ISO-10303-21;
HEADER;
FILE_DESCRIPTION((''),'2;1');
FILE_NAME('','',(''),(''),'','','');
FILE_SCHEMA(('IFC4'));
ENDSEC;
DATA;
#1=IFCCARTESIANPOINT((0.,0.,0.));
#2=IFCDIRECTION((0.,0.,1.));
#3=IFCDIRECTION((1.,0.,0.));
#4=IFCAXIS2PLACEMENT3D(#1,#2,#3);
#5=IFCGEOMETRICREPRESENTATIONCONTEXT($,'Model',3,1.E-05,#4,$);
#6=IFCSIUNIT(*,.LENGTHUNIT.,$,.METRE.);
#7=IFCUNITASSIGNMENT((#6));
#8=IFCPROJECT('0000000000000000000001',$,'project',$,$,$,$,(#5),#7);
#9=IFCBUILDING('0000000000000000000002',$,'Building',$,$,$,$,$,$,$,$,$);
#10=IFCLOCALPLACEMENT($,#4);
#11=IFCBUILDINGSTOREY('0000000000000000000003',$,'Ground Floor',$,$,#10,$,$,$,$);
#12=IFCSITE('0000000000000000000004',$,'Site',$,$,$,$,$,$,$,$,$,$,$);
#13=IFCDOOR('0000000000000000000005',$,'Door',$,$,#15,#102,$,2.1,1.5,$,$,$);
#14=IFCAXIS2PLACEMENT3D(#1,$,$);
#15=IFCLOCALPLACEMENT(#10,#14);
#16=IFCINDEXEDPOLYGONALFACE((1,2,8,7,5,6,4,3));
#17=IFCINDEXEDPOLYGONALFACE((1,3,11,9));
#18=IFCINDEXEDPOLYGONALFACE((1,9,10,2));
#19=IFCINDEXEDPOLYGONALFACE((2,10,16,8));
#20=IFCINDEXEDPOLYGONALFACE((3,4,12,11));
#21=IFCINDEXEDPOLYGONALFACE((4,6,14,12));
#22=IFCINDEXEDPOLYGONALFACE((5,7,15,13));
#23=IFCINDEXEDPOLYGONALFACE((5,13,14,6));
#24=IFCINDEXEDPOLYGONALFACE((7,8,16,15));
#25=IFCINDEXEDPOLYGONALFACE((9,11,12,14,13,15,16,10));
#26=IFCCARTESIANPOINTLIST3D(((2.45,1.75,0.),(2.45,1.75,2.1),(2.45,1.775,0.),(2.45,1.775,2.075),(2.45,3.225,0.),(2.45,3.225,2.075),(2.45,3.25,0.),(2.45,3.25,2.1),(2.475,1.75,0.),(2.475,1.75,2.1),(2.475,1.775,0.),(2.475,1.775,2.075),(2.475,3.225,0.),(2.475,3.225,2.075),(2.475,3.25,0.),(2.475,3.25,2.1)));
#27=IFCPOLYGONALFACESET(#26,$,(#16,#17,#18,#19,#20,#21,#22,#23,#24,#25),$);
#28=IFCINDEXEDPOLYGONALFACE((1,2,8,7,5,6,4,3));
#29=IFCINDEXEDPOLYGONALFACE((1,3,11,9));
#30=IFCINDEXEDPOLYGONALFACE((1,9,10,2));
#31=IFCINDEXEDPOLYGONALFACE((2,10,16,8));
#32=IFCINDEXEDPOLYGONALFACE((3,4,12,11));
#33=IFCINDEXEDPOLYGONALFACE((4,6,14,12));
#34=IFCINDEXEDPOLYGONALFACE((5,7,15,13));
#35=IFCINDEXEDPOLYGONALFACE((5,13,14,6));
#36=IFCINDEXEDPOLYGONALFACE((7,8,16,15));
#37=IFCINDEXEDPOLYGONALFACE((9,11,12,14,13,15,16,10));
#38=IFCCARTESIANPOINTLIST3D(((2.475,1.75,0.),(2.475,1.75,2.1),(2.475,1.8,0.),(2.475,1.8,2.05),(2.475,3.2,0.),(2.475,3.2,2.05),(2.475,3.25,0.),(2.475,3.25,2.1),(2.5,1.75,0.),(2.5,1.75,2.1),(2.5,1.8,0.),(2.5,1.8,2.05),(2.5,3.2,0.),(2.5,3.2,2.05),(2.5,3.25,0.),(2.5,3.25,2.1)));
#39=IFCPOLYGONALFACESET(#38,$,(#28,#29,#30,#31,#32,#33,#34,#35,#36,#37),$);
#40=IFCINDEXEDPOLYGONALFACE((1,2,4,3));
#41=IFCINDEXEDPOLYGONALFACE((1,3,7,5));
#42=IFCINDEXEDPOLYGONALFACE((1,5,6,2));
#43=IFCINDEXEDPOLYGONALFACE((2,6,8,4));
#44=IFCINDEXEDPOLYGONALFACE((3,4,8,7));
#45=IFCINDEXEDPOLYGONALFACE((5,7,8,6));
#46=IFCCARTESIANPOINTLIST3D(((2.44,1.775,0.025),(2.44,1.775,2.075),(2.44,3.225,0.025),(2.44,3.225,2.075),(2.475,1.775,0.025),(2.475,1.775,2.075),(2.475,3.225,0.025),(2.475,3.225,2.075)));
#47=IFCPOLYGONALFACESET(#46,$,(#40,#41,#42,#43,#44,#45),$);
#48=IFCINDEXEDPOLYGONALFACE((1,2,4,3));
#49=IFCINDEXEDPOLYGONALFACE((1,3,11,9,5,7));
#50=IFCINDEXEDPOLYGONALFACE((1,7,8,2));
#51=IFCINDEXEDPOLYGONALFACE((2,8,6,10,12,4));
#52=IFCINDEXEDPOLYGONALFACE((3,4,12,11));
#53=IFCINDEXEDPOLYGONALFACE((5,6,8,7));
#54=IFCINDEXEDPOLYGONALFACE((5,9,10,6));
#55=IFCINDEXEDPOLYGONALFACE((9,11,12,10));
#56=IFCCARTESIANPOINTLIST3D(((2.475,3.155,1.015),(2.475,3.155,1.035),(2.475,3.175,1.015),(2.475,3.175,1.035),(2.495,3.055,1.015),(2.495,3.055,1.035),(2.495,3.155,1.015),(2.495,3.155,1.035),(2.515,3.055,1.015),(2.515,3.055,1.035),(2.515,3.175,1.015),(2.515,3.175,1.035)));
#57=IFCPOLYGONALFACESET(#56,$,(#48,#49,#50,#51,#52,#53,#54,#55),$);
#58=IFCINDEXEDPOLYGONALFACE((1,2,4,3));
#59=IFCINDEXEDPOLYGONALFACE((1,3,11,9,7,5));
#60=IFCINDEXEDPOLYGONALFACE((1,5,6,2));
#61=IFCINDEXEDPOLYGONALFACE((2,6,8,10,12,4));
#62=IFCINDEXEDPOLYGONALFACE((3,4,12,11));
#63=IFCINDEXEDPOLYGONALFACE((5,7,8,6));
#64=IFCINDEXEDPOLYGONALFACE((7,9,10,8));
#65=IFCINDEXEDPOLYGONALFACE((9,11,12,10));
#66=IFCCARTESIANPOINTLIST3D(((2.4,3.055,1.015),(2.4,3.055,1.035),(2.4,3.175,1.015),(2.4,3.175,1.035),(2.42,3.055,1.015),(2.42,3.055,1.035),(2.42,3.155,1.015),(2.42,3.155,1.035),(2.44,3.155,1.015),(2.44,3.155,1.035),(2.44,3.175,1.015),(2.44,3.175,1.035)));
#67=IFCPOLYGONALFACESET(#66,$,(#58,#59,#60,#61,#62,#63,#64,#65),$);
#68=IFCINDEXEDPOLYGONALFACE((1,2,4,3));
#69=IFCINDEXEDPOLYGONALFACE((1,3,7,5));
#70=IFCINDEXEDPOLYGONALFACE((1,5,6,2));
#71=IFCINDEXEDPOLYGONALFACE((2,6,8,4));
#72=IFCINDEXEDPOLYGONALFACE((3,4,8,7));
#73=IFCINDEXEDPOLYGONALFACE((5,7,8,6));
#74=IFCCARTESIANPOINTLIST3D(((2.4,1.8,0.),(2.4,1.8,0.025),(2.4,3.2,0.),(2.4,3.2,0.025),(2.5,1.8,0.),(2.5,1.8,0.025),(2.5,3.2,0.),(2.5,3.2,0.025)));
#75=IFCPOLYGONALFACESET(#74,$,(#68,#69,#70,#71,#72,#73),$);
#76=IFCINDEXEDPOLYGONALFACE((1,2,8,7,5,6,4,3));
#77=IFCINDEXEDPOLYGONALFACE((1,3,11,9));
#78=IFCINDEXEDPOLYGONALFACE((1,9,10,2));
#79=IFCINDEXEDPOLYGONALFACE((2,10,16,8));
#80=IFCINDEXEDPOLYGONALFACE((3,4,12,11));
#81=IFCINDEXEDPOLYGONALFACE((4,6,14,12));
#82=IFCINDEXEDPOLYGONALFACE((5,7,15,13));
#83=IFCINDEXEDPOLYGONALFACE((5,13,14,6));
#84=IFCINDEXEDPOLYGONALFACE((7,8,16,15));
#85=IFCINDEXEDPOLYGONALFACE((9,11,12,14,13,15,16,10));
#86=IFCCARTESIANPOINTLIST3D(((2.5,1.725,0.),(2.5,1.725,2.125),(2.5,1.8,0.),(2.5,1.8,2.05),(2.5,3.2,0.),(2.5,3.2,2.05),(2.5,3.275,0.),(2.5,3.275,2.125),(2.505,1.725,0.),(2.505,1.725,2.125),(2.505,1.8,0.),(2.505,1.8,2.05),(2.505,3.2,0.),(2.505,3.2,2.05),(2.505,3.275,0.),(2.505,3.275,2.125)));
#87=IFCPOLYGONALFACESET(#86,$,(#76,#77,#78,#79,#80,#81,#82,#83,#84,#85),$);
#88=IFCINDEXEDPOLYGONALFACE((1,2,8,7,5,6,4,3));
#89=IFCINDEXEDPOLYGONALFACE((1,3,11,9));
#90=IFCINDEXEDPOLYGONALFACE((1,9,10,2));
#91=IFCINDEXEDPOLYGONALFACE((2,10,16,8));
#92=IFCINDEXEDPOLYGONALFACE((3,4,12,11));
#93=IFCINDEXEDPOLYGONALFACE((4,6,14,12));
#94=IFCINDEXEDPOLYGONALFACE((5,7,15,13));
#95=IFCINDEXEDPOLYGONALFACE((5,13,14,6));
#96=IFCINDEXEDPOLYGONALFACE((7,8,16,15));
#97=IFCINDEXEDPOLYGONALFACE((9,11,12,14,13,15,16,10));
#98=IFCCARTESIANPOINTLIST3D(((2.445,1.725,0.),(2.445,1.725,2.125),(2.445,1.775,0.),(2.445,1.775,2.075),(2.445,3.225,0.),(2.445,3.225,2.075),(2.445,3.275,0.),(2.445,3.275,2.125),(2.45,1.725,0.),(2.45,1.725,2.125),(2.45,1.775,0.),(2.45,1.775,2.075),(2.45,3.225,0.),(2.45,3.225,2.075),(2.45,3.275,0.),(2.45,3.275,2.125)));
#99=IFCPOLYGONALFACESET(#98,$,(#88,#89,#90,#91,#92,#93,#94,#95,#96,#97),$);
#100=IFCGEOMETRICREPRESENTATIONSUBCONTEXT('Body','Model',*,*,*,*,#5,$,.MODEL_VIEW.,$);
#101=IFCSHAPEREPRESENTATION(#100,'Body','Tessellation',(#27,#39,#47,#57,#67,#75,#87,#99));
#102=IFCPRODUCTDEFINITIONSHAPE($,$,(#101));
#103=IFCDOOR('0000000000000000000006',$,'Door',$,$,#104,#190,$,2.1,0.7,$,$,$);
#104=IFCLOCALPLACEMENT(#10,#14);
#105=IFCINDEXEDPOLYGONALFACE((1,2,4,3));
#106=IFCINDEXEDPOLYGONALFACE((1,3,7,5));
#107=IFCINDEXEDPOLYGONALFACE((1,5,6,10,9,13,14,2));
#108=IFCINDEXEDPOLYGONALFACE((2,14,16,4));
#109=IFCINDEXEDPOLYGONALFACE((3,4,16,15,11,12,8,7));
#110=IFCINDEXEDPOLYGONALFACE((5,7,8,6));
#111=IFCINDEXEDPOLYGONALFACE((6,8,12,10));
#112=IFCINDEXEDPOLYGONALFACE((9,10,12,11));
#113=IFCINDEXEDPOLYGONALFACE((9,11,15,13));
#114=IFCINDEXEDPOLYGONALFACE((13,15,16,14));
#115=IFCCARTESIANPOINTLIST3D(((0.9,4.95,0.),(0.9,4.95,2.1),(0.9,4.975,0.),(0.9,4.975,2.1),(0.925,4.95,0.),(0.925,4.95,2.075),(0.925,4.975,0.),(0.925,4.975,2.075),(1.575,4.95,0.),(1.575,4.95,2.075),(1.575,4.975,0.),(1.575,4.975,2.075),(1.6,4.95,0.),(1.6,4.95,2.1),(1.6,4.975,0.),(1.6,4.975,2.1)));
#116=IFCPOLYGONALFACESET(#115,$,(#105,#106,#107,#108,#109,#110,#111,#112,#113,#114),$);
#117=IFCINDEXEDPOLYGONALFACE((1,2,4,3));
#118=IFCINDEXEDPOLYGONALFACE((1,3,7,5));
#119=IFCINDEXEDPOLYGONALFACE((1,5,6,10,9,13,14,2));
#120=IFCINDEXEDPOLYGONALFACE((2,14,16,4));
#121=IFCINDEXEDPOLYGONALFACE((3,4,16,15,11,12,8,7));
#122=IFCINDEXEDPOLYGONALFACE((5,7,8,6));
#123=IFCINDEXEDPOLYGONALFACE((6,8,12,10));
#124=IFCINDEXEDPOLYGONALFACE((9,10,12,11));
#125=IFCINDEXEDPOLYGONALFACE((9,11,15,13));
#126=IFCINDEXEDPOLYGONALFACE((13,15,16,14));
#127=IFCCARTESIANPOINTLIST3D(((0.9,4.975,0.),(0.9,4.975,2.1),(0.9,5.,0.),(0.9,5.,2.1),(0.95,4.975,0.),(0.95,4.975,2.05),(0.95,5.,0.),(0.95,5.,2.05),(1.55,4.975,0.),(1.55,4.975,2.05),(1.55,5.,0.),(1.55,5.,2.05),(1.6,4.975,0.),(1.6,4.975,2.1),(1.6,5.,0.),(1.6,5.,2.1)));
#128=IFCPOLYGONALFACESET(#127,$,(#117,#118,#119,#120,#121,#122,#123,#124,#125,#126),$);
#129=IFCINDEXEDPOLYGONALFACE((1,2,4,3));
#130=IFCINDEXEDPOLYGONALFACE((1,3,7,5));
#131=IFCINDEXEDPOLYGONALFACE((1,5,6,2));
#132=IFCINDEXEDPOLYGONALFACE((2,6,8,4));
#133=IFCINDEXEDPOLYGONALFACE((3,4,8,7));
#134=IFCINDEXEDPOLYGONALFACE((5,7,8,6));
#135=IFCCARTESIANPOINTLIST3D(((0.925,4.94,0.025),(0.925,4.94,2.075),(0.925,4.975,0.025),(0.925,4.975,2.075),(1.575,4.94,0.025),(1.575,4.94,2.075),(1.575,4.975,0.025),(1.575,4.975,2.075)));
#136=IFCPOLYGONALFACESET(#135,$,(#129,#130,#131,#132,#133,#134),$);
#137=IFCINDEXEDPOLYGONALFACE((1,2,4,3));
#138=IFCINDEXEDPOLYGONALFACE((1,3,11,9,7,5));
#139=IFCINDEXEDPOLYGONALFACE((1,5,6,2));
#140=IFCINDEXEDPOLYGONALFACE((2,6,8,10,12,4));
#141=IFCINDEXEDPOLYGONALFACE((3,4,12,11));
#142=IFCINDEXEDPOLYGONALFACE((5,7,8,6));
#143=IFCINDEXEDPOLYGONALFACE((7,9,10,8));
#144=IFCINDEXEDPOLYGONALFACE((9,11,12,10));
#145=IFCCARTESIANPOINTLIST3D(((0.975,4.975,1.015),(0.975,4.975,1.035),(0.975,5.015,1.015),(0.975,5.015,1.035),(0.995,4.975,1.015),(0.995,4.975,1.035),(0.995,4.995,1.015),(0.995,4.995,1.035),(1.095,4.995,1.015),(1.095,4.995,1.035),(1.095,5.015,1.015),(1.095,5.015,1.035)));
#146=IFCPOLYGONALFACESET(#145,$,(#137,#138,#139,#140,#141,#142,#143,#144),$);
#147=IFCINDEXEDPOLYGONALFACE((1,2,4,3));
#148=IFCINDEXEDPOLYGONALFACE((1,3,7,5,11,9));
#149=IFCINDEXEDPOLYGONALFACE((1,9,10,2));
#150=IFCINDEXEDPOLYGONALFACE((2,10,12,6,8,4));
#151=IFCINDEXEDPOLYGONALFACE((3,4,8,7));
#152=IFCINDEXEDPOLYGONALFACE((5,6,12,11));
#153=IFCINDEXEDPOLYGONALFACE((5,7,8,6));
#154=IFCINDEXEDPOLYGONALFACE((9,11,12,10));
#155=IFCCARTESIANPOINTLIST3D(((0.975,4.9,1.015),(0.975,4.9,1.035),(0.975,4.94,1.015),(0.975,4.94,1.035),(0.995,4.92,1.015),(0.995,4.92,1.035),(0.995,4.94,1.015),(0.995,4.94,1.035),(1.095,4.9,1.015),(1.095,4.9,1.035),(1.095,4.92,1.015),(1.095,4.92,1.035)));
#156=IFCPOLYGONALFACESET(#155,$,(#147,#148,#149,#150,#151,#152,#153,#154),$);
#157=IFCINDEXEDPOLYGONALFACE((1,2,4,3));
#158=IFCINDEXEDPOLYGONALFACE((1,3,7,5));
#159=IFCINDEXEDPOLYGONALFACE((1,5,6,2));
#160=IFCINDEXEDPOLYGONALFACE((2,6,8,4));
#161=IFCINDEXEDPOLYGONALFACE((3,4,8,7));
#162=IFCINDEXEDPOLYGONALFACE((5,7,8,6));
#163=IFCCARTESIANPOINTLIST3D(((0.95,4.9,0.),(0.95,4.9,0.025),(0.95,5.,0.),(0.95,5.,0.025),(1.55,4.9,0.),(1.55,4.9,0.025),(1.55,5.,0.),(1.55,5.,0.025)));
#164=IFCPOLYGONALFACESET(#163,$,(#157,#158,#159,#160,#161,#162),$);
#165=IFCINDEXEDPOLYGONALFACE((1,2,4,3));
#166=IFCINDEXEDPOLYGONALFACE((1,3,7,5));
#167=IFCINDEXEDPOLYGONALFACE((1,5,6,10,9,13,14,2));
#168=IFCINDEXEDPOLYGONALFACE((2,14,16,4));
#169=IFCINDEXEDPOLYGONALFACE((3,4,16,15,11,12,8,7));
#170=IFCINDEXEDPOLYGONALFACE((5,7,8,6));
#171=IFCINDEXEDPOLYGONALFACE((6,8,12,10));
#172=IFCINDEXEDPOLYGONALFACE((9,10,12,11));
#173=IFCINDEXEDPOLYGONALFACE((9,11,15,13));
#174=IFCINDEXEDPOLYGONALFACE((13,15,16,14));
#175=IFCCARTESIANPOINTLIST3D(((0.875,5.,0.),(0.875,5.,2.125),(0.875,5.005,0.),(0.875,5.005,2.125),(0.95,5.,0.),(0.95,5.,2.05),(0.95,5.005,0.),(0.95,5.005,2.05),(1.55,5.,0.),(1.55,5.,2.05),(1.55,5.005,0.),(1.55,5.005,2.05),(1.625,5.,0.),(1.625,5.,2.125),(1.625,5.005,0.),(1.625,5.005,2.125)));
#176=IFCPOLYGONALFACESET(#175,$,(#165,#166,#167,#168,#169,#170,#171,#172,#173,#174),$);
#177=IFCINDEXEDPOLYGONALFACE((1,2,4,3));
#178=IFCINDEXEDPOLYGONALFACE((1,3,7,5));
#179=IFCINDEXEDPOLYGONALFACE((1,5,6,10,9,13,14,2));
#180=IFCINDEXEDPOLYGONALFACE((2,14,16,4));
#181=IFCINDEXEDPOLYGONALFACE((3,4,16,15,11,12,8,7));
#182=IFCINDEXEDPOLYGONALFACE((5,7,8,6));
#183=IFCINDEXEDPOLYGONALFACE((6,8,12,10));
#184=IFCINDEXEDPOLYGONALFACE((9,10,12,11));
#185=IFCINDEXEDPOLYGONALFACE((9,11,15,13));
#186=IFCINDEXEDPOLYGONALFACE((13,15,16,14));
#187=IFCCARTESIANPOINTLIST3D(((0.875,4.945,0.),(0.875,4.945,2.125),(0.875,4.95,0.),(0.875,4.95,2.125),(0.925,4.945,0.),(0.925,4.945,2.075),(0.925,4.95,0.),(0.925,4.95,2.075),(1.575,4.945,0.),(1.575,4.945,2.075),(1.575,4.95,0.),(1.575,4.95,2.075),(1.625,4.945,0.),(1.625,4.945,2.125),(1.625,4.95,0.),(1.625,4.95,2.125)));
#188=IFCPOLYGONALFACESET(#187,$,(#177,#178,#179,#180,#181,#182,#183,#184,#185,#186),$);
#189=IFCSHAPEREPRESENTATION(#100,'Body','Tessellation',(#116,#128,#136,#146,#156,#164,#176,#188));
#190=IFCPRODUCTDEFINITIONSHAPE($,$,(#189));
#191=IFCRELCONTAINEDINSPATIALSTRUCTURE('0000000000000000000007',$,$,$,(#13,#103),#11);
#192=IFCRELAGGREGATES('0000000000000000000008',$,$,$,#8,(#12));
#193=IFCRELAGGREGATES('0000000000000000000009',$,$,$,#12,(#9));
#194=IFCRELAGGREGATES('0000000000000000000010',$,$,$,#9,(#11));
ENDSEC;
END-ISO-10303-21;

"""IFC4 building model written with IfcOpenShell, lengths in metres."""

from ifc_helpers import new_model, si_unit, frame, origin_with_axes, place, context, subcontext, project, spatial, line, indexed_curve, outline, extrude, element, save


model = new_model("IFC4")

# Units and contexts
model_context = context("Model", 3, precision=1e-05, world=origin_with_axes())
body_context = subcontext(model_context, "Body", "Model", "MODEL_VIEW")
ifc_project = project(units=[si_unit("LENGTHUNIT", "METRE")], contexts=[model_context])

# Site, building, storey
site = spatial("IfcSite", under=ifc_project, Name="Site")
building = spatial("IfcBuilding", under=site, Name="Building")
storey_placement = place(None, origin_with_axes())
storey = spatial("IfcBuildingStorey", under=building, at=storey_placement, Name="Ground Floor")

# Doors
door_1_placement = place(storey_placement, frame((2.5, 1.75, 0.0), z_axis=(0.0, 0.0, 1.0), x_axis=(0.0, 1.0, 0.0)))
element("IfcDoor", 1, at=door_1_placement, inside=storey, Name="Door", OverallHeight=2.1, OverallWidth=1.5, context=body_context, shape_type="SweptSolid", body=[
    extrude(outline(indexed_curve([(0.0, 0.0), (0.0, 2.1), (1.5, 2.1), (1.5, 0.0), (1.475, 0.0), (1.475, 2.075), (0.025, 2.075), (0.025, 0.0)], segments=[line(1, 2, 3, 4, 5, 6, 7, 8, 1)])), frame((0.0, 0.025, 0.0), z_axis=(0.0, -1.0, 0.0), x_axis=(1.0, 0.0, 0.0)), (0.0, 0.0, -1.0), 0.025),
    extrude(outline(indexed_curve([(0.0, 0.0), (0.0, 2.1), (1.5, 2.1), (1.5, 0.0), (1.45, 0.0), (1.45, 2.05), (0.05, 2.05), (0.05, 0.0)], segments=[line(1, 2, 3, 4, 5, 6, 7, 8, 1)])), frame((0.0, 0.0, 0.0), z_axis=(0.0, -1.0, 0.0), x_axis=(1.0, 0.0, 0.0)), (0.0, 0.0, -1.0), 0.025),
    extrude(outline(indexed_curve([(0.0, 0.0), (1.45, 0.0), (1.45, 0.035), (0.0, 0.035)], segments=[line(1, 2, 3, 4, 1)])), frame((0.025, 0.025, 0.025), z_axis=(0.0, 0.0, 1.0), x_axis=(1.0, 0.0, 0.0)), (0.0, 0.0, 1.0), 2.05),
    extrude(outline(indexed_curve([(0.0, 0.0), (0.0, -0.04), (-0.12, -0.04), (-0.12, -0.02), (-0.02, -0.02), (-0.02, 0.0)], segments=[line(1, 2, 3, 4, 5, 6, 1)])), frame((1.425, 0.025, 1.015), z_axis=(0.0, 0.0, 1.0), x_axis=(1.0, 0.0, 0.0)), (0.0, 0.0, 1.0), 0.02),
    extrude(outline(indexed_curve([(0.0, 0.0), (0.0, 0.04), (-0.12, 0.04), (-0.12, 0.02), (-0.02, 0.02), (-0.02, 0.0)], segments=[line(1, 2, 3, 4, 5, 6, 1)])), frame((1.425, 0.06, 1.015), z_axis=(0.0, 0.0, 1.0), x_axis=(1.0, 0.0, 0.0)), (0.0, 0.0, 1.0), 0.02),
    extrude(outline(indexed_curve([(0.0, 0.0), (1.4, 0.0), (1.4, 0.1), (0.0, 0.1)], segments=[line(1, 2, 3, 4, 1)])), frame((0.05, 0.0, 0.0), z_axis=(0.0, 0.0, 1.0), x_axis=(1.0, 0.0, 0.0)), (0.0, 0.0, 1.0), 0.025),
    extrude(outline(indexed_curve([(0.0, 0.0), (0.0, 2.125), (1.55, 2.125), (1.55, 0.0), (1.475, 0.0), (1.475, 2.05), (0.075, 2.05), (0.075, 0.0)], segments=[line(1, 2, 3, 4, 5, 6, 7, 8, 1)])), frame((-0.025, -0.005, 0.0), z_axis=(0.0, -1.0, 0.0), x_axis=(1.0, 0.0, 0.0)), (0.0, 0.0, -1.0), 0.005),
    extrude(outline(indexed_curve([(0.0, 0.0), (0.0, 2.125), (1.55, 2.125), (1.55, 0.0), (1.5, 0.0), (1.5, 2.075), (0.05, 2.075), (0.05, 0.0)], segments=[line(1, 2, 3, 4, 5, 6, 7, 8, 1)])), frame((-0.025, 0.05, 0.0), z_axis=(0.0, -1.0, 0.0), x_axis=(1.0, 0.0, 0.0)), (0.0, 0.0, -1.0), 0.005),
])
door_2_placement = place(storey_placement, frame((1.6, 5.0, 0.0), z_axis=(0.0, 0.0, 1.0), x_axis=(-1.0, 0.0, 0.0)))
element("IfcDoor", 2, at=door_2_placement, inside=storey, Name="Door", OverallHeight=2.1, OverallWidth=0.7, context=body_context, shape_type="SweptSolid", body=[
    extrude(outline(indexed_curve([(0.0, 0.0), (0.0, 2.1), (0.7, 2.1), (0.7, 0.0), (0.675, 0.0), (0.675, 2.075), (0.025, 2.075), (0.025, 0.0)], segments=[line(1, 2, 3, 4, 5, 6, 7, 8, 1)])), frame((0.0, 0.025, 0.0), z_axis=(0.0, -1.0, 0.0), x_axis=(1.0, 0.0, 0.0)), (0.0, 0.0, -1.0), 0.025),
    extrude(outline(indexed_curve([(0.0, 0.0), (0.0, 2.1), (0.7, 2.1), (0.7, 0.0), (0.65, 0.0), (0.65, 2.05), (0.05, 2.05), (0.05, 0.0)], segments=[line(1, 2, 3, 4, 5, 6, 7, 8, 1)])), frame((0.0, 0.0, 0.0), z_axis=(0.0, -1.0, 0.0), x_axis=(1.0, 0.0, 0.0)), (0.0, 0.0, -1.0), 0.025),
    extrude(outline(indexed_curve([(0.0, 0.0), (0.65, 0.0), (0.65, 0.035), (0.0, 0.035)], segments=[line(1, 2, 3, 4, 1)])), frame((0.025, 0.025, 0.025), z_axis=(0.0, 0.0, 1.0), x_axis=(1.0, 0.0, 0.0)), (0.0, 0.0, 1.0), 2.05),
    extrude(outline(indexed_curve([(0.0, 0.0), (0.0, -0.04), (-0.12, -0.04), (-0.12, -0.02), (-0.02, -0.02), (-0.02, 0.0)], segments=[line(1, 2, 3, 4, 5, 6, 1)])), frame((0.625, 0.025, 1.015), z_axis=(0.0, 0.0, 1.0), x_axis=(1.0, 0.0, 0.0)), (0.0, 0.0, 1.0), 0.02),
    extrude(outline(indexed_curve([(0.0, 0.0), (0.0, 0.04), (-0.12, 0.04), (-0.12, 0.02), (-0.02, 0.02), (-0.02, 0.0)], segments=[line(1, 2, 3, 4, 5, 6, 1)])), frame((0.625, 0.06, 1.015), z_axis=(0.0, 0.0, 1.0), x_axis=(1.0, 0.0, 0.0)), (0.0, 0.0, 1.0), 0.02),
    extrude(outline(indexed_curve([(0.0, 0.0), (0.6, 0.0), (0.6, 0.1), (0.0, 0.1)], segments=[line(1, 2, 3, 4, 1)])), frame((0.05, 0.0, 0.0), z_axis=(0.0, 0.0, 1.0), x_axis=(1.0, 0.0, 0.0)), (0.0, 0.0, 1.0), 0.025),
    extrude(outline(indexed_curve([(0.0, 0.0), (0.0, 2.125), (0.75, 2.125), (0.75, 0.0), (0.675, 0.0), (0.675, 2.05), (0.075, 2.05), (0.075, 0.0)], segments=[line(1, 2, 3, 4, 5, 6, 7, 8, 1)])), frame((-0.025, -0.005, 0.0), z_axis=(0.0, -1.0, 0.0), x_axis=(1.0, 0.0, 0.0)), (0.0, 0.0, -1.0), 0.005),
    extrude(outline(indexed_curve([(0.0, 0.0), (0.0, 2.125), (0.75, 2.125), (0.75, 0.0), (0.7, 0.0), (0.7, 2.075), (0.05, 2.075), (0.05, 0.0)], segments=[line(1, 2, 3, 4, 5, 6, 7, 8, 1)])), frame((-0.025, 0.05, 0.0), z_axis=(0.0, -1.0, 0.0), x_axis=(1.0, 0.0, 0.0)), (0.0, 0.0, -1.0), 0.005),
])

save(model, "model.ifc")
